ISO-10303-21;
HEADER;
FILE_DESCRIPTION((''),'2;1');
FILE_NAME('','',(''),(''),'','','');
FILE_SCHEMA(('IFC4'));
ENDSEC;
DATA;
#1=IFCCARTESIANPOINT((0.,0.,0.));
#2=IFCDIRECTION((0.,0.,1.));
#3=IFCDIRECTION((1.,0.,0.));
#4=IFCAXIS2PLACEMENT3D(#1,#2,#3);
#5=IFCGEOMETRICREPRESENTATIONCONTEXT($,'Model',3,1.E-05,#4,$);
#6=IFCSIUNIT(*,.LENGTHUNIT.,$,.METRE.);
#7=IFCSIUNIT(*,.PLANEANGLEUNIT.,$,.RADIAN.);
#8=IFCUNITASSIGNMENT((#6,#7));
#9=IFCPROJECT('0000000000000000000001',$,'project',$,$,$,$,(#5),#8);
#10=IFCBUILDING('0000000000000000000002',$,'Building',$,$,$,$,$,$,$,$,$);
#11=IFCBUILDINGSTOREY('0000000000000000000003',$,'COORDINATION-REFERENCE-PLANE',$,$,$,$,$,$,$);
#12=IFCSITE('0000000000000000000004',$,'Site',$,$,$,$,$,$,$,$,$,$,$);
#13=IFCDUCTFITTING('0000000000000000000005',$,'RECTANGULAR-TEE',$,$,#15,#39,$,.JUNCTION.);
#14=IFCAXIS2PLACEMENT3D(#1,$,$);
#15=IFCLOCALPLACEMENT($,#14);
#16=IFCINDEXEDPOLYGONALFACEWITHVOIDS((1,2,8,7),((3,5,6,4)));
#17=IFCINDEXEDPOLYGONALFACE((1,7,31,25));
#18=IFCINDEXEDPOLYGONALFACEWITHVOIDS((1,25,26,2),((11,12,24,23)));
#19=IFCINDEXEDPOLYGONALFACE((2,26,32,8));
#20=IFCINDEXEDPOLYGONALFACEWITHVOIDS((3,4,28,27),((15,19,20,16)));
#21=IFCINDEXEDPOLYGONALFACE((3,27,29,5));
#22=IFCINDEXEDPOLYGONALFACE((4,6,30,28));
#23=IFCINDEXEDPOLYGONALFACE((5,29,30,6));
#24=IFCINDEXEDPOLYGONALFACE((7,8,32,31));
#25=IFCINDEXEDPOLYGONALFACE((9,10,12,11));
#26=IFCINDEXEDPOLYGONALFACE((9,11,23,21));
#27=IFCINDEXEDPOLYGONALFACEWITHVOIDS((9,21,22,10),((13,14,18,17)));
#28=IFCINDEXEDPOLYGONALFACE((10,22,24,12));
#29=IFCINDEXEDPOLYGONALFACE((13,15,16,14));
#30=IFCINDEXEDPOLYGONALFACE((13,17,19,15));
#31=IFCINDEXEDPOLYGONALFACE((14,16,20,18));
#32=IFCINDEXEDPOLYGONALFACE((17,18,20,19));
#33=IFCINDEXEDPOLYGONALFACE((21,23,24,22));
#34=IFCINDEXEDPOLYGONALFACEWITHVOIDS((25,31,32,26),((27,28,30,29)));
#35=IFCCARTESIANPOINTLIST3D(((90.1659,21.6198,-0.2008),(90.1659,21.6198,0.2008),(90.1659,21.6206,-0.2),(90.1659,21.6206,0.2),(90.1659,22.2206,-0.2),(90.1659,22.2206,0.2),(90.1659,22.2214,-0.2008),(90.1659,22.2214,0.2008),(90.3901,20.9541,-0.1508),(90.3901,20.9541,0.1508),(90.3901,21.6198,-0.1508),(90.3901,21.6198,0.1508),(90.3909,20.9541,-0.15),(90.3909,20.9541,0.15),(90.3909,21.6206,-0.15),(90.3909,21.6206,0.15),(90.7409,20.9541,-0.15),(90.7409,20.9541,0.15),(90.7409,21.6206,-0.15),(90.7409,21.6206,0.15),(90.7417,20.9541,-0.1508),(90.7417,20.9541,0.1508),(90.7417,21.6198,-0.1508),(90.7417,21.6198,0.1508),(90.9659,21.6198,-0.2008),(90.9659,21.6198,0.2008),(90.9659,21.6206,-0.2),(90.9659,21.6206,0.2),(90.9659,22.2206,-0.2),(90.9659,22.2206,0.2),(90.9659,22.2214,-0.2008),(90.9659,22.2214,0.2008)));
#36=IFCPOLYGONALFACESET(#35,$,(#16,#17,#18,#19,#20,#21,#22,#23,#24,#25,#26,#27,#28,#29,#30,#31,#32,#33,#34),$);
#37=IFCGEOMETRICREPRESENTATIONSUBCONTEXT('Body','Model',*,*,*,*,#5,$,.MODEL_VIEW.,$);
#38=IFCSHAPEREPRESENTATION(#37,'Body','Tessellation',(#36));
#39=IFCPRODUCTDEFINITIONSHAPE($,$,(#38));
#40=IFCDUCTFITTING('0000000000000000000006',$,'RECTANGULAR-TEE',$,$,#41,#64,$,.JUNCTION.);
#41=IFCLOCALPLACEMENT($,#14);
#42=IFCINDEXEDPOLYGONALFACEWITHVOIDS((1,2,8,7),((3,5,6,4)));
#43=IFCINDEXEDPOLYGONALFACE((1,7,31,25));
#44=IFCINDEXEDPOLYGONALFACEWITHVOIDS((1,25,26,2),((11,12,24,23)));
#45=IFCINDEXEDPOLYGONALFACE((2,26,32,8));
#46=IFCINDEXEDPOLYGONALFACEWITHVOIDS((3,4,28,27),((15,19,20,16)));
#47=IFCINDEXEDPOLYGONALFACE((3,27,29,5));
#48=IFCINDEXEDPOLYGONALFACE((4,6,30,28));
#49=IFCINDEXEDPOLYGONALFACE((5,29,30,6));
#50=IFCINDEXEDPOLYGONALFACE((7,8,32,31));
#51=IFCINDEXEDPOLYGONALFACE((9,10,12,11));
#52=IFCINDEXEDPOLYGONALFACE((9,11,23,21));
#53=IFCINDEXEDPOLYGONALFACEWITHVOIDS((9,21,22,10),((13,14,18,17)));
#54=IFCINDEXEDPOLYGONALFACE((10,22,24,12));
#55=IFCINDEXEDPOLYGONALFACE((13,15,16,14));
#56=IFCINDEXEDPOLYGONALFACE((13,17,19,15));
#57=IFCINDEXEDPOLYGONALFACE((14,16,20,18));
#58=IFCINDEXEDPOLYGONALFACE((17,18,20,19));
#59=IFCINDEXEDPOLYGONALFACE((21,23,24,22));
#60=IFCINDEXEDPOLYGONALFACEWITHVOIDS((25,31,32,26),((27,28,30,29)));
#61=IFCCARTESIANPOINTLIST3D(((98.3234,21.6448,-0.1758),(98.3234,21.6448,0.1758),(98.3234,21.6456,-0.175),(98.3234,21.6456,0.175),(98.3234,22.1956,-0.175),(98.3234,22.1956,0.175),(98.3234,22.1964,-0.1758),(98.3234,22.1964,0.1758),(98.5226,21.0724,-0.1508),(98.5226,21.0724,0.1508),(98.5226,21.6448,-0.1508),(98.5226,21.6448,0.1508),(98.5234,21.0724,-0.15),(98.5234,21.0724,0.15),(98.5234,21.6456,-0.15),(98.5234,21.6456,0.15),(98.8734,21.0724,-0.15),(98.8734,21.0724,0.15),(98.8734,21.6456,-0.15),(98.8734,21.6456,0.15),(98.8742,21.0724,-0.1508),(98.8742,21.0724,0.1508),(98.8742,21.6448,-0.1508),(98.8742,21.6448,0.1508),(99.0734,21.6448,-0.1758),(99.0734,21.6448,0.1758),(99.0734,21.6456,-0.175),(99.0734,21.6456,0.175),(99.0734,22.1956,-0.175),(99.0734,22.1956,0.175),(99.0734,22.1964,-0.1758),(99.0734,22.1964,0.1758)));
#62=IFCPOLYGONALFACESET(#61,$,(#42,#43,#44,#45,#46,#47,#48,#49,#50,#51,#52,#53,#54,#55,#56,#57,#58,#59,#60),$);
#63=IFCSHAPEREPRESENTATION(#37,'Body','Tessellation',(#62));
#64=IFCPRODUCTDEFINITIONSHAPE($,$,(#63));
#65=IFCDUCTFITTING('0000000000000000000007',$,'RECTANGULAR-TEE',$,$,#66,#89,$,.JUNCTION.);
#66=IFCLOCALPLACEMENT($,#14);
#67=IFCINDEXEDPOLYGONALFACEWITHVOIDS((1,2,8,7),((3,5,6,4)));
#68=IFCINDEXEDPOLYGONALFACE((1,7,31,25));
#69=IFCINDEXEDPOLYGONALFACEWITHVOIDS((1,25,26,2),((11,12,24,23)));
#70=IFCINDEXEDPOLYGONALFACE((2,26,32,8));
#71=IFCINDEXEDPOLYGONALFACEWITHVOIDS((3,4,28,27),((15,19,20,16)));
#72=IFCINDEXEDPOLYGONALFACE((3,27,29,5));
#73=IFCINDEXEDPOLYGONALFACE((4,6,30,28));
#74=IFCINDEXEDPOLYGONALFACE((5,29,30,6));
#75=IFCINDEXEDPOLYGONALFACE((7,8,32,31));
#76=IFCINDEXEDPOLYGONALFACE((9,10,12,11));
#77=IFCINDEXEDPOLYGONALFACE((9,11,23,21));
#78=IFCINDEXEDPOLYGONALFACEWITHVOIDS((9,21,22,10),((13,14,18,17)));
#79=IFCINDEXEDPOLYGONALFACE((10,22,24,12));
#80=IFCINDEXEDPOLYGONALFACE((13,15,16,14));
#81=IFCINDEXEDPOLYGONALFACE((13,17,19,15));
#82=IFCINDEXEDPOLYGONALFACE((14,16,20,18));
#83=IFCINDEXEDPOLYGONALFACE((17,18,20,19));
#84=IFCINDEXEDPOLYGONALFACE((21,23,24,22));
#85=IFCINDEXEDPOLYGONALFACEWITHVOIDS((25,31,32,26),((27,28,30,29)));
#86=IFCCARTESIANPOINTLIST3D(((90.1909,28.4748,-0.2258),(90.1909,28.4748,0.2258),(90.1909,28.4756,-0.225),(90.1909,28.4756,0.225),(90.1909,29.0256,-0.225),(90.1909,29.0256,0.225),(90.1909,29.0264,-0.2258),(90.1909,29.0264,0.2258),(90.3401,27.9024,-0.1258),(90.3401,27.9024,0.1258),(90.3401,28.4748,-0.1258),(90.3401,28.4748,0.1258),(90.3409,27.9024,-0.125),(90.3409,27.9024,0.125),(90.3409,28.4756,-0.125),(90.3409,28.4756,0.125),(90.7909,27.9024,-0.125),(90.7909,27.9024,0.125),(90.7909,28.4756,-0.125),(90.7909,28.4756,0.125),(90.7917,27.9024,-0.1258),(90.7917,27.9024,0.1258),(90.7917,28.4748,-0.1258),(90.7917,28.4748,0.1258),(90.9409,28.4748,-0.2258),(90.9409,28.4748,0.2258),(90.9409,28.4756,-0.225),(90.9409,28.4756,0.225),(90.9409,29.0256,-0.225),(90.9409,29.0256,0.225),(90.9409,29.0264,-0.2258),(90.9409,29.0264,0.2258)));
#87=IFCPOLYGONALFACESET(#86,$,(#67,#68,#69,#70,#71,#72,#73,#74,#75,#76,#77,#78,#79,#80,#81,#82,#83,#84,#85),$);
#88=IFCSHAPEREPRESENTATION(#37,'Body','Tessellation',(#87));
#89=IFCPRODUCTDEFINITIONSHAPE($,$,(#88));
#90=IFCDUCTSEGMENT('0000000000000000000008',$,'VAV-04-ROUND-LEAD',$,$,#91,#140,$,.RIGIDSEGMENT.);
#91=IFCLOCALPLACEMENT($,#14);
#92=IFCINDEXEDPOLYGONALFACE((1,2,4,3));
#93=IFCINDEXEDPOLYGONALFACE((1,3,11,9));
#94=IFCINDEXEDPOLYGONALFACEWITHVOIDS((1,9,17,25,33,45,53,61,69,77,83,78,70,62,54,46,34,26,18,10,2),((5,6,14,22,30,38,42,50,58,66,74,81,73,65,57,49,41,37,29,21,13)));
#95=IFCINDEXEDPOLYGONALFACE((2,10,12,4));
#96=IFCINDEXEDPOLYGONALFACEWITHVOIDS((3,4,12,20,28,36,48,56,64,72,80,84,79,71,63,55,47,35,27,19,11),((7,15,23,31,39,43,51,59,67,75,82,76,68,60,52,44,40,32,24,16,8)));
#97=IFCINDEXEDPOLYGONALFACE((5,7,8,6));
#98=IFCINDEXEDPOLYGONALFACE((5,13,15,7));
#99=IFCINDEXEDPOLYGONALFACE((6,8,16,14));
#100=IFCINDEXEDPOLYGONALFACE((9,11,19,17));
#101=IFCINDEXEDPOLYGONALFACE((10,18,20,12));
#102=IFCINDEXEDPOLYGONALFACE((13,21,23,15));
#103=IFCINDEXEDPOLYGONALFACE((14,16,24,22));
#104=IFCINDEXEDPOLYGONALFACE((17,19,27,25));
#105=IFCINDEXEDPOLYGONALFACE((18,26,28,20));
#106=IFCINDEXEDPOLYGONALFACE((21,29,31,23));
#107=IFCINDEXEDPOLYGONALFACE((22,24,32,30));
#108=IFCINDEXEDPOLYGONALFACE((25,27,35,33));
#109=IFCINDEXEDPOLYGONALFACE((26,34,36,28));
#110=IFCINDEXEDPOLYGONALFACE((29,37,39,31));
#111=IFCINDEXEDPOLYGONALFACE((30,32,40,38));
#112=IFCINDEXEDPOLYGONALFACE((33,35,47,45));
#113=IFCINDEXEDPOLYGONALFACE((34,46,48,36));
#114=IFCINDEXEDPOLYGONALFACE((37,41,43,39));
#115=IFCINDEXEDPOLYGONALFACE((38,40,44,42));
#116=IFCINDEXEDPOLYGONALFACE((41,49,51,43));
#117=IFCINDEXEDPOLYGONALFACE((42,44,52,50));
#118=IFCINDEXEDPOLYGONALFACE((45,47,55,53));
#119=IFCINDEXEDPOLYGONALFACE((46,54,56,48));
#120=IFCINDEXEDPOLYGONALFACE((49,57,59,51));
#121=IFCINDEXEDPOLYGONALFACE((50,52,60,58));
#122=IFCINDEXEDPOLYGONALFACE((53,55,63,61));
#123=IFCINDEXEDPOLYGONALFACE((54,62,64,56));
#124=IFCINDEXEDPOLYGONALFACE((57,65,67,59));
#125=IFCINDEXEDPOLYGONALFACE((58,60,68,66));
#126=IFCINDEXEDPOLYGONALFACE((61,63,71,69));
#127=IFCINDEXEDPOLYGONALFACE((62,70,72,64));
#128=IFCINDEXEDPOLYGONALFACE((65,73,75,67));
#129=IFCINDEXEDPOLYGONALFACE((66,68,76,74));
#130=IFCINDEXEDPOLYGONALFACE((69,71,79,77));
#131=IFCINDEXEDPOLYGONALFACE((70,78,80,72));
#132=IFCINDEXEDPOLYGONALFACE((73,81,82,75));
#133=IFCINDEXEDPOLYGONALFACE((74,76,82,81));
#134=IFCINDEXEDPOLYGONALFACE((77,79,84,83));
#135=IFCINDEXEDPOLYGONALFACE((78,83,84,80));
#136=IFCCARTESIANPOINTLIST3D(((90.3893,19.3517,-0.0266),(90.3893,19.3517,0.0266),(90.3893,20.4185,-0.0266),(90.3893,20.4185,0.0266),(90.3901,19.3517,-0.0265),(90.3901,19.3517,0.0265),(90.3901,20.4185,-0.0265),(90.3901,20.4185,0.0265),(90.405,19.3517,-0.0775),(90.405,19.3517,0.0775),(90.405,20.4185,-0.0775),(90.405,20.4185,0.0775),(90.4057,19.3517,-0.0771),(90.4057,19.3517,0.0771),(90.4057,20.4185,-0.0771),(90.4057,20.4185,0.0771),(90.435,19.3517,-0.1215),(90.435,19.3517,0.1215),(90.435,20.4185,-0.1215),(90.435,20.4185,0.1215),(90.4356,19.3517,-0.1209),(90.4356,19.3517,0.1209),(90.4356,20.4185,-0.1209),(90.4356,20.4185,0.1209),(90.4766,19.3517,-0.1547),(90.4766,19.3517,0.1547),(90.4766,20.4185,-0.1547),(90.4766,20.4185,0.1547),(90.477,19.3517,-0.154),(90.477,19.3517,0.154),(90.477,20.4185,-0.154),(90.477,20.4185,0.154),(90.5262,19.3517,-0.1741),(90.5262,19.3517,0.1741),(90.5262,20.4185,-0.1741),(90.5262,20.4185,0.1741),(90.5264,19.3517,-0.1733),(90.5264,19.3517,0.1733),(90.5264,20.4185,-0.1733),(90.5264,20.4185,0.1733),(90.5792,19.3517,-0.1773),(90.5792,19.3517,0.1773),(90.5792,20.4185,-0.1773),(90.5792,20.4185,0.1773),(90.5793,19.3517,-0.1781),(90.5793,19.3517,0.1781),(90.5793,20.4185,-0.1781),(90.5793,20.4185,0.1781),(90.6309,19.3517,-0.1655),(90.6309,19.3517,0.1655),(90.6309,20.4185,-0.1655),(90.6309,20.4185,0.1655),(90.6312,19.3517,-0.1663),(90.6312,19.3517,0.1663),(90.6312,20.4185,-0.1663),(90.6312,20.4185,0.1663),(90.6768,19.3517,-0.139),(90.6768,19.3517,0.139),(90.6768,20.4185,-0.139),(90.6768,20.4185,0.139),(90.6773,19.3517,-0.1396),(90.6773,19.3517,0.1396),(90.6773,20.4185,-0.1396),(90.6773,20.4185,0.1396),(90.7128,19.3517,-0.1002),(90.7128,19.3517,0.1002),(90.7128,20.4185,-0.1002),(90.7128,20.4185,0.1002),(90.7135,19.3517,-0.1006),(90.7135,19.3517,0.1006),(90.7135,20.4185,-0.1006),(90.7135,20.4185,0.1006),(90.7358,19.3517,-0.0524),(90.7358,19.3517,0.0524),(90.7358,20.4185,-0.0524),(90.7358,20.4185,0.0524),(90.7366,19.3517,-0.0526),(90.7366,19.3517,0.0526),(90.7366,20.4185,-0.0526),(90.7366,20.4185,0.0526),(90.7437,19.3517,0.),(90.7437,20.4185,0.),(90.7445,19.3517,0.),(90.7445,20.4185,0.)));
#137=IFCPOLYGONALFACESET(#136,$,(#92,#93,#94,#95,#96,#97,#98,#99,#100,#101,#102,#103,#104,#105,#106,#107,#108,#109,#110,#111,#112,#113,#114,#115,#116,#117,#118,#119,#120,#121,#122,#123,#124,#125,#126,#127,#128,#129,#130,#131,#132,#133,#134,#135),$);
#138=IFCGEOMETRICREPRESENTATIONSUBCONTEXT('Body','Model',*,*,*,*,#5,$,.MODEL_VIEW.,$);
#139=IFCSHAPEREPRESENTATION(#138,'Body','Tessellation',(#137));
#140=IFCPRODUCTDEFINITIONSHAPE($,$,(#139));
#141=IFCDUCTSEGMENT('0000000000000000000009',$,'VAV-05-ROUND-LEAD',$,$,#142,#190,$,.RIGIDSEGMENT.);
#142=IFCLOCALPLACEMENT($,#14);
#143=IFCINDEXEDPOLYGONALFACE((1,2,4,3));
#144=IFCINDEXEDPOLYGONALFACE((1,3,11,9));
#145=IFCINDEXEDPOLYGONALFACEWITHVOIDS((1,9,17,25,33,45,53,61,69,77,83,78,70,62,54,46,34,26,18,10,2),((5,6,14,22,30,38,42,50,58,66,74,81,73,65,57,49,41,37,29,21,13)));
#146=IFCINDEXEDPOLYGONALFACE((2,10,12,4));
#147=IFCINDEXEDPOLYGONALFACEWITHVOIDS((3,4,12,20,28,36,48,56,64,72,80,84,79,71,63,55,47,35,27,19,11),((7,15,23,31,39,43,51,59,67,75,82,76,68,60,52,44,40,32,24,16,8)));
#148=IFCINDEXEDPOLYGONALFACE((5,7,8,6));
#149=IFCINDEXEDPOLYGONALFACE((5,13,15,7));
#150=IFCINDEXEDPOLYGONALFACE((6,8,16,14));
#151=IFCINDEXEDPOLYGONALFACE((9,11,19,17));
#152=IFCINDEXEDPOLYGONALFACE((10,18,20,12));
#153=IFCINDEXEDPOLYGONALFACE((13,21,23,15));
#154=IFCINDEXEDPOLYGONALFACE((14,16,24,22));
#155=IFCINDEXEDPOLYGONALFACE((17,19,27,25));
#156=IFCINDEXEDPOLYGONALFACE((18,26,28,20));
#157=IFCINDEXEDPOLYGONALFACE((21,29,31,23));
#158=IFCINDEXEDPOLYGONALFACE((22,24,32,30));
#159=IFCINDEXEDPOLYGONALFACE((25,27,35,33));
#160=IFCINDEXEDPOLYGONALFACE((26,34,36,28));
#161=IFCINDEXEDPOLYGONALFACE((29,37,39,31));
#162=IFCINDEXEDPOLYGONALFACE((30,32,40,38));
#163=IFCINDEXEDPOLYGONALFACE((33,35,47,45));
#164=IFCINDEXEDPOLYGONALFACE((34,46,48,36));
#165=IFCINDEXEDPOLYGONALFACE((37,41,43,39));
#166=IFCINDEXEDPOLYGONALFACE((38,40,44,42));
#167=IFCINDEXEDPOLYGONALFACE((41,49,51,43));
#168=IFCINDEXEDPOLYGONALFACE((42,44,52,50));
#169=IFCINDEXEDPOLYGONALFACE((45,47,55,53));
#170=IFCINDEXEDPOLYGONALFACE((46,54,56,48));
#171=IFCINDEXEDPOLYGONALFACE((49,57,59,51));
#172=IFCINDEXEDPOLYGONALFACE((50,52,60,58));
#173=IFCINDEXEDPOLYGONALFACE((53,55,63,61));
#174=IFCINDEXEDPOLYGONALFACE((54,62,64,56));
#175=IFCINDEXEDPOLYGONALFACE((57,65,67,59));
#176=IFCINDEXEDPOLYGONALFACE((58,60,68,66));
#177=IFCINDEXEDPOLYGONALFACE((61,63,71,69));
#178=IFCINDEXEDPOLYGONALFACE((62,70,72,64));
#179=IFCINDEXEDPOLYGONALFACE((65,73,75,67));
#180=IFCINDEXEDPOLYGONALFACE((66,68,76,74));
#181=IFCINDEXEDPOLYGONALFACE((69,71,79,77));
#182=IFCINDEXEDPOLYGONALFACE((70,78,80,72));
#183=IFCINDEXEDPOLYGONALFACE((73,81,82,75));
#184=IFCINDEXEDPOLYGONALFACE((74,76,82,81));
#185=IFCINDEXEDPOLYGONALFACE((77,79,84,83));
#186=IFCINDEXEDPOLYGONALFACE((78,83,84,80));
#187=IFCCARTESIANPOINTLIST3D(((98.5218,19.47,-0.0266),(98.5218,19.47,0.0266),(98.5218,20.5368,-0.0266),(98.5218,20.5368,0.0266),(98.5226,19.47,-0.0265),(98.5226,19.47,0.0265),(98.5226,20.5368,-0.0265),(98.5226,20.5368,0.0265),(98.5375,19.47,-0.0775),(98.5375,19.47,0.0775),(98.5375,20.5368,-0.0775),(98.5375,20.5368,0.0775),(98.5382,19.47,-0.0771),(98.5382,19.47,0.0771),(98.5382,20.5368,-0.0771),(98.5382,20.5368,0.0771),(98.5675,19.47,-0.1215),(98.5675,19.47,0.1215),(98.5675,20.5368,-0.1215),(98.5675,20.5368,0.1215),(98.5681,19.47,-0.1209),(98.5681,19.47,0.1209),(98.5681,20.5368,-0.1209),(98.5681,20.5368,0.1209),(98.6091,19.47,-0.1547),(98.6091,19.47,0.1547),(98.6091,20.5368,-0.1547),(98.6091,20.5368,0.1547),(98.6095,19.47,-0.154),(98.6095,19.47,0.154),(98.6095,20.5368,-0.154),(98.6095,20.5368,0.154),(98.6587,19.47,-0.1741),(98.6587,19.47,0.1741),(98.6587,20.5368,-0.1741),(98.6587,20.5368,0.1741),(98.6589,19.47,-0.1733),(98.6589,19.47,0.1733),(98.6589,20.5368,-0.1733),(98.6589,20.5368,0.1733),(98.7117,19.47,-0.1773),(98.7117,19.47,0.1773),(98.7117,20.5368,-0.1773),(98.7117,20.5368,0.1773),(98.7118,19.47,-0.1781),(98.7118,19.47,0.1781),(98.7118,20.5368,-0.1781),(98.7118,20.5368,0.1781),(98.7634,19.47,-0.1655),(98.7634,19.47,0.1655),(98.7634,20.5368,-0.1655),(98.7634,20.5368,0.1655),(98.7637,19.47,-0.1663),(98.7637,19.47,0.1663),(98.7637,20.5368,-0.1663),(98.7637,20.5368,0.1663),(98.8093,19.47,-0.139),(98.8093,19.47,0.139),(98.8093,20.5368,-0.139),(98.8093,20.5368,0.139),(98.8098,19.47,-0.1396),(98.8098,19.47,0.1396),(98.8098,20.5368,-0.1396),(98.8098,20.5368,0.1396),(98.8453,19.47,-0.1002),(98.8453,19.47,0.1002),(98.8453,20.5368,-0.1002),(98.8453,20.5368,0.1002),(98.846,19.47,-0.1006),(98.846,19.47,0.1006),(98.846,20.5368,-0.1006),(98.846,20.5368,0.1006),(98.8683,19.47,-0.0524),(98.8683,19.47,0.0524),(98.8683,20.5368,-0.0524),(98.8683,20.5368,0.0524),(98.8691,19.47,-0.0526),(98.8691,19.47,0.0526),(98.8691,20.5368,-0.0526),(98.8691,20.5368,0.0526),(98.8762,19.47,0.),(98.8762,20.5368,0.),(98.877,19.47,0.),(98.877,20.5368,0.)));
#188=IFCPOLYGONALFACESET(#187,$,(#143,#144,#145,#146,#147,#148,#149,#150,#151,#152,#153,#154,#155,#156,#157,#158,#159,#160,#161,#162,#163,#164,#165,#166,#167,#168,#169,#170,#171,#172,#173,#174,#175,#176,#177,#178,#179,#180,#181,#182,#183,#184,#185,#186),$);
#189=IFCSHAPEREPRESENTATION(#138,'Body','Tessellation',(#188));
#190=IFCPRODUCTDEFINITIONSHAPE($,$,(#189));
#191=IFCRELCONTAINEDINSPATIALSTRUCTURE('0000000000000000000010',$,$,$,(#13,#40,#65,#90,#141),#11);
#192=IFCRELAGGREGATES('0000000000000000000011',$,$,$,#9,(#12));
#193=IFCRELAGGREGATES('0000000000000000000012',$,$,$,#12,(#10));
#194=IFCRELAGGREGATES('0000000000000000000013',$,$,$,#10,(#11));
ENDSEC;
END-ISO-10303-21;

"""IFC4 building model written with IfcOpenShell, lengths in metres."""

from ifc_helpers import new_model, si_unit, frame, origin, origin_with_axes, place, context, subcontext, project, spatial, rectangle, hollow_circle, extrude, boolean, element, save


model = new_model("IFC4")

# Units and contexts
model_context = context("Model", 3, precision=1e-05, world=origin_with_axes())
body_context_1 = subcontext(model_context, "Body", "Model", "MODEL_VIEW")
body_context_2 = subcontext(model_context, "Body", "Model", "MODEL_VIEW")
ifc_project = project(units=[si_unit("LENGTHUNIT", "METRE"), si_unit("PLANEANGLEUNIT", "RADIAN")], contexts=[model_context])

# Site, building, storey
site = spatial("IfcSite", under=ifc_project, Name="Site")
building = spatial("IfcBuilding", under=site, Name="Building")
storey = spatial("IfcBuildingStorey", under=building, Name="COORDINATION-REFERENCE-PLANE")

# Duct fittings
duct_fitting_1_placement = place(None, frame((90.5659, 21.9206, 0.0), z_axis=(1.0, 0.0, 0.0), x_axis=(0.0, -1.0, 0.0)))
solid_1 = boolean("UNION", extrude(rectangle(XDim=0.6, YDim=0.4), frame((0.0, 0.0, -0.4), z_axis=(0.0, 0.0, 1.0), x_axis=(1.0, 0.0, 0.0)), (0.0, 0.0, 1.0), 0.8), extrude(rectangle(XDim=0.35, YDim=0.3), frame((0.0, 0.0, 0.0), z_axis=(1.0, 0.0, 0.0), x_axis=(0.0, 0.0, -1.0)), (0.0, 0.0, 1.0), 0.9665))
element("IfcDuctFitting", 1, at=duct_fitting_1_placement, inside=storey, Name="RECTANGULAR-TEE", PredefinedType="JUNCTION", context=body_context_1, shape_type="CSG", body=[
    boolean("DIFFERENCE", boolean("UNION", extrude(rectangle(XDim=0.6016, YDim=0.4016), frame((0.0, 0.0, -0.4), z_axis=(0.0, 0.0, 1.0), x_axis=(1.0, 0.0, 0.0)), (0.0, 0.0, 1.0), 0.8), extrude(rectangle(XDim=0.3516, YDim=0.3016), frame((0.0, 0.0, 0.0), z_axis=(1.0, 0.0, 0.0), x_axis=(0.0, 0.0, -1.0)), (0.0, 0.0, 1.0), 0.9665)), solid_1),
])
duct_fitting_2_placement = place(None, frame((98.6984, 21.9206, 0.0), z_axis=(1.0, 0.0, 0.0), x_axis=(0.0, -1.0, 0.0)))
solid_2 = boolean("UNION", extrude(rectangle(XDim=0.55, YDim=0.35), frame((0.0, 0.0, -0.375), z_axis=(0.0, 0.0, 1.0), x_axis=(1.0, 0.0, 0.0)), (0.0, 0.0, 1.0), 0.75), extrude(rectangle(XDim=0.35, YDim=0.3), frame((0.0, 0.0, 0.0), z_axis=(1.0, 0.0, 0.0), x_axis=(0.0, 0.0, -1.0)), (0.0, 0.0, 1.0), 0.8482))
element("IfcDuctFitting", 2, at=duct_fitting_2_placement, inside=storey, Name="RECTANGULAR-TEE", PredefinedType="JUNCTION", context=body_context_1, shape_type="CSG", body=[
    boolean("DIFFERENCE", boolean("UNION", extrude(rectangle(XDim=0.5516, YDim=0.3516), frame((0.0, 0.0, -0.375), z_axis=(0.0, 0.0, 1.0), x_axis=(1.0, 0.0, 0.0)), (0.0, 0.0, 1.0), 0.75), extrude(rectangle(XDim=0.3516, YDim=0.3016), frame((0.0, 0.0, 0.0), z_axis=(1.0, 0.0, 0.0), x_axis=(0.0, 0.0, -1.0)), (0.0, 0.0, 1.0), 0.8482)), solid_2),
])
duct_fitting_3_placement = place(None, frame((90.5659, 28.7506, 0.0), z_axis=(1.0, 0.0, 0.0), x_axis=(0.0, -1.0, 0.0)))
solid_3 = boolean("UNION", extrude(rectangle(XDim=0.55, YDim=0.45), frame((0.0, 0.0, -0.375), z_axis=(0.0, 0.0, 1.0), x_axis=(1.0, 0.0, 0.0)), (0.0, 0.0, 1.0), 0.75), extrude(rectangle(XDim=0.45, YDim=0.25), frame((0.0, 0.0, 0.0), z_axis=(1.0, 0.0, 0.0), x_axis=(0.0, 0.0, -1.0)), (0.0, 0.0, 1.0), 0.8482))
element("IfcDuctFitting", 3, at=duct_fitting_3_placement, inside=storey, Name="RECTANGULAR-TEE", PredefinedType="JUNCTION", context=body_context_1, shape_type="CSG", body=[
    boolean("DIFFERENCE", boolean("UNION", extrude(rectangle(XDim=0.5516, YDim=0.4516), frame((0.0, 0.0, -0.375), z_axis=(0.0, 0.0, 1.0), x_axis=(1.0, 0.0, 0.0)), (0.0, 0.0, 1.0), 0.75), extrude(rectangle(XDim=0.4516, YDim=0.2516), frame((0.0, 0.0, 0.0), z_axis=(1.0, 0.0, 0.0), x_axis=(0.0, 0.0, -1.0)), (0.0, 0.0, 1.0), 0.8482)), solid_3),
])

# Duct segments
for number, where, z_axis, x_axis, name in (
    (4, (90.5659, 20.4185, 0.0), (0.0, -1.0, 0.0), (1.0, 0.0, 0.0), "VAV-04-ROUND-LEAD"),
    (5, (98.6984, 20.5368, 0.0), (0.0, -1.0, 0.0), (1.0, 0.0, 0.0), "VAV-05-ROUND-LEAD"),
):
    element("IfcDuctSegment", number, at=place(None, frame(where, z_axis=z_axis, x_axis=x_axis)), inside=storey, Name=name, PredefinedType="RIGIDSEGMENT", context=body_context_2, shape_type="SweptSolid", body=[
        extrude(hollow_circle(Radius=0.1786, WallThickness=0.0008), origin(), (0.0, 0.0, 1.0), 1.0668),
    ])

save(model, "model.ifc")
